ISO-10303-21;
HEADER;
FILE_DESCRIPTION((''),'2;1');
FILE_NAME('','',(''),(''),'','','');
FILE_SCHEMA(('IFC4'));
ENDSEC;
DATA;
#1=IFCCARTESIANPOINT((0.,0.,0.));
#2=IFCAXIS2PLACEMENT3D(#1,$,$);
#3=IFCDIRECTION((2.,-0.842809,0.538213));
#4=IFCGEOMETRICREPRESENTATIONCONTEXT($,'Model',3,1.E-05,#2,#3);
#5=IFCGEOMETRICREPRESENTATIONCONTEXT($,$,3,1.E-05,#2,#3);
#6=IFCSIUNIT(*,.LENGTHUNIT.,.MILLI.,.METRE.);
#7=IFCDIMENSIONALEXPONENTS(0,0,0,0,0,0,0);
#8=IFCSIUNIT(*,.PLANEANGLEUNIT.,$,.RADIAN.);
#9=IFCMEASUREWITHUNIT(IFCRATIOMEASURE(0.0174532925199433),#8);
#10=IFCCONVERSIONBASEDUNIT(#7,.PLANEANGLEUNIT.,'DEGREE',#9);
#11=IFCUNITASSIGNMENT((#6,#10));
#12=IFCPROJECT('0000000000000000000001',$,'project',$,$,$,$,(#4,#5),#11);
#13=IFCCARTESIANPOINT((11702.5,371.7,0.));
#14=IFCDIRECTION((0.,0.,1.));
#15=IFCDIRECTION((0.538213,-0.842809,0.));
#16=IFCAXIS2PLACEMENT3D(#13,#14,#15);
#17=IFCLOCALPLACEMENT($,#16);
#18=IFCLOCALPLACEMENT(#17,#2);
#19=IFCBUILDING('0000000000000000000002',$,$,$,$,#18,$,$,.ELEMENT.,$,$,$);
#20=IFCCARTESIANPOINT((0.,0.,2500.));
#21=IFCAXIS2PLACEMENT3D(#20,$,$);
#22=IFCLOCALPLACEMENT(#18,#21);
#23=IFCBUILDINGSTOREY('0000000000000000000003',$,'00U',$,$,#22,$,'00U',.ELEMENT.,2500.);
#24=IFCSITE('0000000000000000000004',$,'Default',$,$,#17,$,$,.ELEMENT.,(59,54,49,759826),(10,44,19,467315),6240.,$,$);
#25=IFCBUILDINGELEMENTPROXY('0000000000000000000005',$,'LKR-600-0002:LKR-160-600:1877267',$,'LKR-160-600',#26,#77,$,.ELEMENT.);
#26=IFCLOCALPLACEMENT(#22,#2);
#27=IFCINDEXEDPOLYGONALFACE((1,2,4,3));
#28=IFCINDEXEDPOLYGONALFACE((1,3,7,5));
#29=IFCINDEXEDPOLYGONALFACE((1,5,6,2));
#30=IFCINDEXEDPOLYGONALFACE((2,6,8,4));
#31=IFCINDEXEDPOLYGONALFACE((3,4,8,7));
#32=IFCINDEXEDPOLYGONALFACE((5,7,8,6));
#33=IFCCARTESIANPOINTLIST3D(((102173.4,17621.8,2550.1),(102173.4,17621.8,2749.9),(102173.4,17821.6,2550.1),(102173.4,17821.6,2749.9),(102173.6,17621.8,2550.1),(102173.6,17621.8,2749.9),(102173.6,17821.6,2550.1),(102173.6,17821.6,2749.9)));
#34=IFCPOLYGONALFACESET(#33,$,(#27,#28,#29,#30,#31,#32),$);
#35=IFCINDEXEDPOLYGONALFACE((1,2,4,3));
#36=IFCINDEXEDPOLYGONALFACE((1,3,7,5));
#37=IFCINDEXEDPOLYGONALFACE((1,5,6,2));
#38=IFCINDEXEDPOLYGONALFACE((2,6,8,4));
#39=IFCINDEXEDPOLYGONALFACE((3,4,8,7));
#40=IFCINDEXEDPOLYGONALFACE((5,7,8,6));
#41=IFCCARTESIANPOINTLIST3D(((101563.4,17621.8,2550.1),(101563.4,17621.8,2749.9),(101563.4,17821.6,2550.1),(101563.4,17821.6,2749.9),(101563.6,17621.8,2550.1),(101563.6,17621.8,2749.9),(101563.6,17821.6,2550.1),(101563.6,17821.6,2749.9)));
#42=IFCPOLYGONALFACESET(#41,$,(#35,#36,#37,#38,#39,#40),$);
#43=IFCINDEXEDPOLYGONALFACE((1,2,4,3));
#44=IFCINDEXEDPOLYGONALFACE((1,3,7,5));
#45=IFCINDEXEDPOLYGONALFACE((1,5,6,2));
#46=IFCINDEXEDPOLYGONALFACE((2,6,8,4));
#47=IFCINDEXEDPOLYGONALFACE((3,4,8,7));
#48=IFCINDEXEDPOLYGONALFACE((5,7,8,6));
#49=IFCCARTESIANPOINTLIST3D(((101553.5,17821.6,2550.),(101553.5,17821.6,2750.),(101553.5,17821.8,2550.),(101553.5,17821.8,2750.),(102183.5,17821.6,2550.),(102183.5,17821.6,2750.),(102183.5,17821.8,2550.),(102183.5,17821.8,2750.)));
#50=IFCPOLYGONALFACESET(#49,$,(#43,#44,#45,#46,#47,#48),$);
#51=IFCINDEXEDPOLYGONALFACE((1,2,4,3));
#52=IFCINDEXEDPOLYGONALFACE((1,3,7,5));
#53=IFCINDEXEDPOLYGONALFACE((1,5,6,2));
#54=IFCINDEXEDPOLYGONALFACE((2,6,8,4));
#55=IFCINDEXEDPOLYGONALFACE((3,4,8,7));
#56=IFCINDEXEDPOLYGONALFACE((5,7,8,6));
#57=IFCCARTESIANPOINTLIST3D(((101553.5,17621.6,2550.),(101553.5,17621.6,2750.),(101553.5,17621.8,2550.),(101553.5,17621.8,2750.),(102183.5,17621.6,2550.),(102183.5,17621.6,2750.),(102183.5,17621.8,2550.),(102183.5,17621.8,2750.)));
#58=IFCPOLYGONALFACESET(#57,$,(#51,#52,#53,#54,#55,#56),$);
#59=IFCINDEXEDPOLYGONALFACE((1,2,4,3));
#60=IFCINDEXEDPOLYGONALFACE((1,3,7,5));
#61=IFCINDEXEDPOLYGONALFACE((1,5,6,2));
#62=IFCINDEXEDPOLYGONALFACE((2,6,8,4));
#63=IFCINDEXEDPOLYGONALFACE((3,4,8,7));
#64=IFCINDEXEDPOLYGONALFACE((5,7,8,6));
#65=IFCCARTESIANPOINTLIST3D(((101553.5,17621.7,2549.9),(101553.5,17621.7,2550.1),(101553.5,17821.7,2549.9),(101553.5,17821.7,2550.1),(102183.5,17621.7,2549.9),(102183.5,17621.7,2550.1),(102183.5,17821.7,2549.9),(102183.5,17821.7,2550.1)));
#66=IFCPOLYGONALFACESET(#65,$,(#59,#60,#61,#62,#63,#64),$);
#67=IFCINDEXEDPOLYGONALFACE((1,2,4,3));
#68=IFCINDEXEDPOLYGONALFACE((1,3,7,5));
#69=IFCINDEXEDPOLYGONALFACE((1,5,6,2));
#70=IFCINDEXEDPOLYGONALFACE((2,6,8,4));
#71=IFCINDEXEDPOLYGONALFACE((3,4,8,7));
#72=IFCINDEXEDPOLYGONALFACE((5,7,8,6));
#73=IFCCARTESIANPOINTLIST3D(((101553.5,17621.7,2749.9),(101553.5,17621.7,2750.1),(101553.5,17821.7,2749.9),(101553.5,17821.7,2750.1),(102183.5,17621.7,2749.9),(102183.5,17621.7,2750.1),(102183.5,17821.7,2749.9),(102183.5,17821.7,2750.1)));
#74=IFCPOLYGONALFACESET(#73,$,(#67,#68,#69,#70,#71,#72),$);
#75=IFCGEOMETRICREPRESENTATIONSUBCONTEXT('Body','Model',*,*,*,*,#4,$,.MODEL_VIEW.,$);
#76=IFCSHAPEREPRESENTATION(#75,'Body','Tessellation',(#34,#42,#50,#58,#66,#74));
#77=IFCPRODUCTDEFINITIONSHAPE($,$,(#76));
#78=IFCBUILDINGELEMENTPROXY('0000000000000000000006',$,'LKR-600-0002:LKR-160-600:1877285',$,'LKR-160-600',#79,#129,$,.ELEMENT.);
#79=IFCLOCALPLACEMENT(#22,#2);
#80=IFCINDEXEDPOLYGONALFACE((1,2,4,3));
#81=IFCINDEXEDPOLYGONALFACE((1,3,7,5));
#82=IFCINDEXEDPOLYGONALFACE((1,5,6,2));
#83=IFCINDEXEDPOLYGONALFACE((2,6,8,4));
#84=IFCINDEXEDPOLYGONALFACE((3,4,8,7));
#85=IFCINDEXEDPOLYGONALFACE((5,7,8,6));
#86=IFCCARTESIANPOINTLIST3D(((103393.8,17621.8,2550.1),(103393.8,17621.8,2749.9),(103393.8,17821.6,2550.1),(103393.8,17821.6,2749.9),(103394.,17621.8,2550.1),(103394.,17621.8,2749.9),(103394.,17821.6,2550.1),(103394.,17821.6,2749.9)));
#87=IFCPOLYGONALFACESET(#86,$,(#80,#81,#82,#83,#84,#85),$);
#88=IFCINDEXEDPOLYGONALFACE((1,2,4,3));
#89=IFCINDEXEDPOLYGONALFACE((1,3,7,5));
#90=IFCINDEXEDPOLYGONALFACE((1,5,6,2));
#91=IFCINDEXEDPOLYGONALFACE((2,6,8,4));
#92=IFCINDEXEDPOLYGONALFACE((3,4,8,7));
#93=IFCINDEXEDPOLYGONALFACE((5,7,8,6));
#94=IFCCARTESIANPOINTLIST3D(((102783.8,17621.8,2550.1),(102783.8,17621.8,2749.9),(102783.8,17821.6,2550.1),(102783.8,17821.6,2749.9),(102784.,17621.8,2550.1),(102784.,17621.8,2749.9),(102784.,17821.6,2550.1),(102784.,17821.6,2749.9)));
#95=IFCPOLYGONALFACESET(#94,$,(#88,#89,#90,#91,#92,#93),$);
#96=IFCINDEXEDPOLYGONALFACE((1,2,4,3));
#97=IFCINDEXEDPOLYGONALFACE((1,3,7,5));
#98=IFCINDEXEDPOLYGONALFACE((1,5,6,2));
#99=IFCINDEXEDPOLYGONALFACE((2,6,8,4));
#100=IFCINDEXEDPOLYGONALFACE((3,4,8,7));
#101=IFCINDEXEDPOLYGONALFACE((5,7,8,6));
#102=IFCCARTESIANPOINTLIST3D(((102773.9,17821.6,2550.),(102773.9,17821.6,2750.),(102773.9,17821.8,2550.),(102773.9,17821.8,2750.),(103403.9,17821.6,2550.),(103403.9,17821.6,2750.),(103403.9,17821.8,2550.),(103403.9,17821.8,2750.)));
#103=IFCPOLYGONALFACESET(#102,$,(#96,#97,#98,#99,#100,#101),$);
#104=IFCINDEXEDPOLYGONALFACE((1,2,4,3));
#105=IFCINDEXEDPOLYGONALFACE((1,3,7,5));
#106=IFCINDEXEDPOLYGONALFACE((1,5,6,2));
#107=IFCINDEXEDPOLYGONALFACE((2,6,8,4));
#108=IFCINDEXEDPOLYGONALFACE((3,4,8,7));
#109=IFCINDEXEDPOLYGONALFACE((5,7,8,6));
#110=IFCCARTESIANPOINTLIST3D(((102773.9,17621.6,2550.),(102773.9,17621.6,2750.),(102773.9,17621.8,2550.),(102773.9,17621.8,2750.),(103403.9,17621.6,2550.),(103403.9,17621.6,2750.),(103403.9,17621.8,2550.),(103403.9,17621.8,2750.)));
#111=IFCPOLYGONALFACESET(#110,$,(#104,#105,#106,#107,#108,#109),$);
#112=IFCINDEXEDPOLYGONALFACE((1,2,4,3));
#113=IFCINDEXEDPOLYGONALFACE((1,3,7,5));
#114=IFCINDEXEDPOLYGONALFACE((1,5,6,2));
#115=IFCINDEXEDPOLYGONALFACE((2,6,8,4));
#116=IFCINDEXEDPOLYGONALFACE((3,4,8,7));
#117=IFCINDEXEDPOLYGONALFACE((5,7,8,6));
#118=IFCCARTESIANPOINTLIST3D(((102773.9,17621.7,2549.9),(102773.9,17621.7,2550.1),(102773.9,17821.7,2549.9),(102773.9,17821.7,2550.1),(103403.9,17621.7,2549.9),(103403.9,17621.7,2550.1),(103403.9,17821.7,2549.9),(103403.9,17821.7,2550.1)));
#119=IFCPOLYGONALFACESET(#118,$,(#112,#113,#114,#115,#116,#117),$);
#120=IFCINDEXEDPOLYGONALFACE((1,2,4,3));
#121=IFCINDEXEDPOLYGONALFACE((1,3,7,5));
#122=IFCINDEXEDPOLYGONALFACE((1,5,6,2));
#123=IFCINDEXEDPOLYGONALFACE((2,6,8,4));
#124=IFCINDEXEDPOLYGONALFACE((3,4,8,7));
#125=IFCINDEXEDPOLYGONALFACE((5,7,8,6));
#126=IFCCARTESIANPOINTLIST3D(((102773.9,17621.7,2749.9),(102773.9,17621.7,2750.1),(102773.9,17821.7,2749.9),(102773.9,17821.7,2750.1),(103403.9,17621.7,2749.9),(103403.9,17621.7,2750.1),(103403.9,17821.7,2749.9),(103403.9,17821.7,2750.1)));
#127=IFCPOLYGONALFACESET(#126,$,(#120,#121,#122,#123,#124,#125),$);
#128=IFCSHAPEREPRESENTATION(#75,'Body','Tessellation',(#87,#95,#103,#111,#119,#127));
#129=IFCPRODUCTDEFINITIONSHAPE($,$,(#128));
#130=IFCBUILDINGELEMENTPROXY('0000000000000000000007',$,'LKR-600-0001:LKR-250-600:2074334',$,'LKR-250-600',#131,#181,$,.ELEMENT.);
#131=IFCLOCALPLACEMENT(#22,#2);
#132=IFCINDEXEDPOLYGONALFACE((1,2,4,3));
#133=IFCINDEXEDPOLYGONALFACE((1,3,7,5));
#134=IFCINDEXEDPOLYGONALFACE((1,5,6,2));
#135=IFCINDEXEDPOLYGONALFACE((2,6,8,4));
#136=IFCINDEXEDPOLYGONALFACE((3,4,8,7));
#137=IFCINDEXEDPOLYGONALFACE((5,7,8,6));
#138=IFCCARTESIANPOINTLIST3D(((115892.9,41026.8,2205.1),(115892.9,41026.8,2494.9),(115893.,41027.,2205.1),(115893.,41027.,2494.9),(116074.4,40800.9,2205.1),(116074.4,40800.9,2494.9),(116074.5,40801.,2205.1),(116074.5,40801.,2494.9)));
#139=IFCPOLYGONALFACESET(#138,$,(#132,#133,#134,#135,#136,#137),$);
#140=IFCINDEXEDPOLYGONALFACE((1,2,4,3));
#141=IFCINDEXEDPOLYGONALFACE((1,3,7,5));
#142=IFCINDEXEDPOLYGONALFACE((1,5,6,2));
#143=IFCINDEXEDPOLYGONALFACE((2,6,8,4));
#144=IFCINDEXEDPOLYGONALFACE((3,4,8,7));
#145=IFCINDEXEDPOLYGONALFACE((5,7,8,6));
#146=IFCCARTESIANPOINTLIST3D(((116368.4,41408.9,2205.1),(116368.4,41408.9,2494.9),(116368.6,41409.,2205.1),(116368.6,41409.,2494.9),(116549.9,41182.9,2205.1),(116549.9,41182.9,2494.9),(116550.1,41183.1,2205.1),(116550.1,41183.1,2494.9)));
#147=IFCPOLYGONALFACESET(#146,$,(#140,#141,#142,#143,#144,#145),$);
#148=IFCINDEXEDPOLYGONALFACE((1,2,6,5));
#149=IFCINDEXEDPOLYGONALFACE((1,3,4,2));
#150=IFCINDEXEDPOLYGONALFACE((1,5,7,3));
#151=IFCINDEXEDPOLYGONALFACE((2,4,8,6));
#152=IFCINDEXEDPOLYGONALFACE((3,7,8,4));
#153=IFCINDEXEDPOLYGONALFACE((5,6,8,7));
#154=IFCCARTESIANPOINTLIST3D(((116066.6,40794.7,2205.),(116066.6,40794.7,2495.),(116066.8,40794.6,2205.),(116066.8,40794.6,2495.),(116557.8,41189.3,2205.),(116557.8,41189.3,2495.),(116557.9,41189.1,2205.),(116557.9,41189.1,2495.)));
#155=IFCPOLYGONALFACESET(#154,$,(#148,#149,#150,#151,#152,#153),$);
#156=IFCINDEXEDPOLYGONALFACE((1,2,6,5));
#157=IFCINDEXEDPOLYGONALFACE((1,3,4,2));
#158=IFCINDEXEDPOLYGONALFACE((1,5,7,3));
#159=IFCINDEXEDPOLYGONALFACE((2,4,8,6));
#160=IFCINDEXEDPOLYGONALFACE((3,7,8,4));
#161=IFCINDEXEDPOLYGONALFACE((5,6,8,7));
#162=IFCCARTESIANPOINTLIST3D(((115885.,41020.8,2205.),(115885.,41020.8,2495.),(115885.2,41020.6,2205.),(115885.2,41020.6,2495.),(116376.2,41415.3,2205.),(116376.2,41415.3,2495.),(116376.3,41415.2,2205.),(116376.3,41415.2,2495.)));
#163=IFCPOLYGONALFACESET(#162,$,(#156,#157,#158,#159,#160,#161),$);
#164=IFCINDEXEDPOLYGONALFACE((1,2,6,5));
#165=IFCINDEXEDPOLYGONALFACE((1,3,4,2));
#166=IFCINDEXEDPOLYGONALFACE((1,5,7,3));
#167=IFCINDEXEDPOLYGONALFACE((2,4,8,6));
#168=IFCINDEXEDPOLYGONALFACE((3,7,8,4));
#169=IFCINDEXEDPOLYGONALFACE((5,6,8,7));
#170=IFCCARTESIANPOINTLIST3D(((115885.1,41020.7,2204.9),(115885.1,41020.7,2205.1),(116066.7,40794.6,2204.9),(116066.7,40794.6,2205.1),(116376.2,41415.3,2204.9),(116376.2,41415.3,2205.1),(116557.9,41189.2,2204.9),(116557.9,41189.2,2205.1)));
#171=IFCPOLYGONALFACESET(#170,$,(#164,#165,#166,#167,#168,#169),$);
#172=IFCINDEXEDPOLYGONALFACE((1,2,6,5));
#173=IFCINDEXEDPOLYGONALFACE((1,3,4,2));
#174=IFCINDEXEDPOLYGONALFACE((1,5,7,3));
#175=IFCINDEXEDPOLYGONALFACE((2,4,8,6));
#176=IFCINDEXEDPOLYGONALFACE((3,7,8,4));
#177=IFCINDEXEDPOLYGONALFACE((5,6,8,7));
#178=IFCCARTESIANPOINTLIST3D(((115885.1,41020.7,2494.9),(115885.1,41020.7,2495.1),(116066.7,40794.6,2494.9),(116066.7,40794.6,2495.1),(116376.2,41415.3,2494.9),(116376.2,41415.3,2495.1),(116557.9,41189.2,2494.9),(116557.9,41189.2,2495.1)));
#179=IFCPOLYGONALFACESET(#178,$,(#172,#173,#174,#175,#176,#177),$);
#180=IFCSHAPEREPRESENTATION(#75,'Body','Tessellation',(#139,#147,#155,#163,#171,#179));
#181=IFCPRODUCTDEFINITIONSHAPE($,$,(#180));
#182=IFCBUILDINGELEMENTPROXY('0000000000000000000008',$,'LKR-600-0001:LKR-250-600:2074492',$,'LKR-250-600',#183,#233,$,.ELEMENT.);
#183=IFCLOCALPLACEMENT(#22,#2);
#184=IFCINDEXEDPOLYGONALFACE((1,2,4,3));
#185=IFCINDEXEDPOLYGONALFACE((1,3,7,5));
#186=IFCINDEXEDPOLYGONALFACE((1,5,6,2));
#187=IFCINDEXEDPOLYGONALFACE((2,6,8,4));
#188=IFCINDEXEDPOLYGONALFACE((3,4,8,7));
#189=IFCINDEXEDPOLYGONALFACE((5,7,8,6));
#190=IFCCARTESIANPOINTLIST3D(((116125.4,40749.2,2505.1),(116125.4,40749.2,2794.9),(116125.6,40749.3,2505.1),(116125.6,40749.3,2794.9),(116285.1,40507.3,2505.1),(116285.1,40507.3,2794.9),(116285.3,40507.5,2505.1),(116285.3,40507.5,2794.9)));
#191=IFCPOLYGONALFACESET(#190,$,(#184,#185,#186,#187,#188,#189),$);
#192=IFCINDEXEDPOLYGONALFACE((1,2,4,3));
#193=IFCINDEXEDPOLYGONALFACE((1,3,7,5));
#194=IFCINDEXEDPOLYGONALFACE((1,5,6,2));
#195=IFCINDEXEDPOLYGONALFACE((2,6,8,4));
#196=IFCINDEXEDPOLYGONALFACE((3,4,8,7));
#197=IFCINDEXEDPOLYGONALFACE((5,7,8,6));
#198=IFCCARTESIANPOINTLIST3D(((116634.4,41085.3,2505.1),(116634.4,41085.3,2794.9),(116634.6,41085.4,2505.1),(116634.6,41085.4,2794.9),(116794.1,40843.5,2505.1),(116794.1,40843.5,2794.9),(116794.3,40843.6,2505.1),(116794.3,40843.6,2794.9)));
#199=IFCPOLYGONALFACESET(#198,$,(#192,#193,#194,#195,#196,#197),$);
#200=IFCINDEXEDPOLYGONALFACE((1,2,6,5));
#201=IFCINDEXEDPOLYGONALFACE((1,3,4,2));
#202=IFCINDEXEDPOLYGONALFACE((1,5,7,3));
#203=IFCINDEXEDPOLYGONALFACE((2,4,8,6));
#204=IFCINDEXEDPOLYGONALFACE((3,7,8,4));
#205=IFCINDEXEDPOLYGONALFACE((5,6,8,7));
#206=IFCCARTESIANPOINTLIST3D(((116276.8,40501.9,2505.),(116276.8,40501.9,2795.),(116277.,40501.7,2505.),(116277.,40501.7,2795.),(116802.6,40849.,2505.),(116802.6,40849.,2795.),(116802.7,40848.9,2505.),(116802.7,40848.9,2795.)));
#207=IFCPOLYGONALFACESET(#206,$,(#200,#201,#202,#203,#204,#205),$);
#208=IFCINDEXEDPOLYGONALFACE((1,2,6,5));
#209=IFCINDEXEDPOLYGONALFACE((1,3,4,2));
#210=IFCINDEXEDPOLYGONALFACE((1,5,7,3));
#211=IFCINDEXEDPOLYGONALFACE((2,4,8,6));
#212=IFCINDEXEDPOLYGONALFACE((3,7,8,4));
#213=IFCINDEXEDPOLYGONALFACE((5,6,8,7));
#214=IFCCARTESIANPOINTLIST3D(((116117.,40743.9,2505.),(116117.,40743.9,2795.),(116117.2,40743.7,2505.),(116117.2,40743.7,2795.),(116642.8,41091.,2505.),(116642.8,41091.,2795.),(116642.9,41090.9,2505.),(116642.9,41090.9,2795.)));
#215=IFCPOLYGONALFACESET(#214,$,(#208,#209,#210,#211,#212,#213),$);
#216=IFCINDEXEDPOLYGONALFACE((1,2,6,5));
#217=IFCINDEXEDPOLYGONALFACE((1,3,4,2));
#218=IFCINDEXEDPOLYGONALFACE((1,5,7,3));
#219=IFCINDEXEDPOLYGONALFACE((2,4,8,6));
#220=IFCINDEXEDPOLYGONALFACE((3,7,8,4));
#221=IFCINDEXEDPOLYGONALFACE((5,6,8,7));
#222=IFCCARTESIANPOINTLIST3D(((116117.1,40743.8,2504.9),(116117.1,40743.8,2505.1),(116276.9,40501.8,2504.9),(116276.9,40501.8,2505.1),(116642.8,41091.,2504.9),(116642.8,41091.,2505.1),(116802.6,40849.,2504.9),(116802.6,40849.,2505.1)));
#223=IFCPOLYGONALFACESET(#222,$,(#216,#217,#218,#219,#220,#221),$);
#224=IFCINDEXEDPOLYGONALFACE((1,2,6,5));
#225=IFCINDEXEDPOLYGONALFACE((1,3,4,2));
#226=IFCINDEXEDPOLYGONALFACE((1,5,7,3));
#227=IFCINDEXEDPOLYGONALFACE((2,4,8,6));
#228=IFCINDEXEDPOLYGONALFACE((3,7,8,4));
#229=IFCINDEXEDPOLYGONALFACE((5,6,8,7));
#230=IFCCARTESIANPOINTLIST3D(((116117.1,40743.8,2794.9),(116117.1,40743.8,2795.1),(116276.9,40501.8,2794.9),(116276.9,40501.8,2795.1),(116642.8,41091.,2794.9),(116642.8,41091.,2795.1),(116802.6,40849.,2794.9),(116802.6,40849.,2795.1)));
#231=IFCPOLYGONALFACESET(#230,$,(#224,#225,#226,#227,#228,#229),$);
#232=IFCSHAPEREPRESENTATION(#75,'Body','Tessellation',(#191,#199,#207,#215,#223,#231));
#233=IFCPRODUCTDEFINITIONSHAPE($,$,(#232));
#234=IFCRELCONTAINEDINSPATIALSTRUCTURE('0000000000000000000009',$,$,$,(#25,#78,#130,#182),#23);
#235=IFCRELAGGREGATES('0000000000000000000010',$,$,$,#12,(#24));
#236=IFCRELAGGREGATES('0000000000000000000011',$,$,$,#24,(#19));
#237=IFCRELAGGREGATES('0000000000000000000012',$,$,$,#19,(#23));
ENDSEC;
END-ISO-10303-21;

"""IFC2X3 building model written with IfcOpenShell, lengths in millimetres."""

from ifc_helpers import new_model, entity, si_unit, converted_unit, direction, frame, frame_2d, origin, origin_2d_with_axis, place, context, subcontext, project, spatial, rectangle, extrude, source, transform, mapped, element, save


model = new_model("IFC2X3")

# Units and contexts
model_context = context("Model", 3, precision=1e-05, world=origin(), true_north=direction((2.0, -0.842809, 0.538213)))
context_of_model = context(None, 3, precision=1e-05, world=origin(), true_north=direction((2.0, -0.842809, 0.538213)))
body_context = subcontext(model_context, "Body", "Model", "MODEL_VIEW")
ifc_project = project(units=[si_unit("LENGTHUNIT", "METRE", prefix="MILLI"), converted_unit("PLANEANGLEUNIT", "DEGREE", entity("IfcRatioMeasure", 0.0174532925199433), si_unit("PLANEANGLEUNIT", "RADIAN"), dimensions=[0, 0, 0, 0, 0, 0, 0])], contexts=[model_context, context_of_model])

# Site, building, storey
site_placement = place(None, frame((11702.5, 371.7, 0.0), z_axis=(0.0, 0.0, 1.0), x_axis=(0.538213, -0.842809, 0.0)))
site = spatial("IfcSite", under=ifc_project, at=site_placement, Name="Default", CompositionType="ELEMENT", RefLatitude=(59, 54, 49, 759826), RefLongitude=(10, 44, 19, 467315), RefElevation=6240.0)
building_placement = place(site_placement, origin())
building = spatial("IfcBuilding", under=site, at=building_placement, CompositionType="ELEMENT")
storey_placement = place(building_placement, frame((0.0, 0.0, 2500.0)))
storey = spatial("IfcBuildingStorey", under=building, at=storey_placement, Name="00U", LongName="00U", CompositionType="ELEMENT", Elevation=2500.0)

# Building element proxies
shared_shape_1 = source(origin(), body_context, "Body", "SweptSolid", [
    extrude(rectangle(XDim=0.2, YDim=199.8, at=frame_2d((0.0, 0.0), x_axis=(1.0, 0.0))), frame((305.0, 0.0, -99.9)), (0.0, 0.0, 1.0), 199.8),
    extrude(rectangle(XDim=0.2, YDim=199.8, at=frame_2d((0.0, 0.0), x_axis=(1.0, 0.0))), frame((-305.0, 0.0, -99.9)), (0.0, 0.0, 1.0), 199.8),
    extrude(rectangle(XDim=0.2, YDim=630.0, at=frame_2d((0.0, 0.0), x_axis=(1.0, 0.0))), frame((0.0, 100.0, -100.0), z_axis=(0.0, 0.0, 1.0), x_axis=(0.0, 1.0, 0.0)), (0.0, 0.0, 1.0), 200.0),
    extrude(rectangle(XDim=0.2, YDim=630.0, at=frame_2d((0.0, 0.0), x_axis=(1.0, 0.0))), frame((0.0, -100.0, -100.0), z_axis=(0.0, 0.0, 1.0), x_axis=(0.0, 1.0, 0.0)), (0.0, 0.0, 1.0), 200.0),
    extrude(rectangle(XDim=200.0, YDim=630.0, at=origin_2d_with_axis()), frame((0.0, 0.0, -100.1), z_axis=(0.0, 0.0, 1.0), x_axis=(0.0, -1.0, 0.0)), (0.0, 0.0, 1.0), 0.2),
    extrude(rectangle(XDim=200.0, YDim=630.0, at=origin_2d_with_axis()), frame((0.0, 0.0, 99.9), z_axis=(0.0, 0.0, 1.0), x_axis=(0.0, -1.0, 0.0)), (0.0, 0.0, 1.0), 0.2),
])
for number, where, name in (
    (1, (101868.5, 17721.7, 2650.0), "LKR-600-0002:LKR-160-600:1877267"),
    (2, (103088.9, 17721.7, 2650.0), "LKR-600-0002:LKR-160-600:1877285"),
):
    element("IfcBuildingElementProxy", number, at=place(storey_placement, frame(where)), inside=storey, Name=name, ObjectType="LKR-160-600", CompositionType="ELEMENT", context=body_context, shape_type="MappedRepresentation", body=[
        mapped(shared_shape_1, transform((0.0, 0.0, 0.0), scale=1.0)),
    ])
shared_shape_2 = source(origin(), body_context, "Body", "SweptSolid", [
    extrude(rectangle(XDim=0.2, YDim=289.8, at=frame_2d((0.0, 0.0), x_axis=(1.0, 0.0))), frame((305.0, 0.0, -144.9)), (0.0, 0.0, 1.0), 289.8),
    extrude(rectangle(XDim=0.2, YDim=289.8, at=frame_2d((0.0, 0.0), x_axis=(1.0, 0.0))), frame((-305.0, 0.0, -144.9)), (0.0, 0.0, 1.0), 289.8),
    extrude(rectangle(XDim=0.2, YDim=630.0, at=frame_2d((0.0, 0.0), x_axis=(1.0, 0.0))), frame((0.0, 145.0, -145.0), z_axis=(0.0, 0.0, 1.0), x_axis=(0.0, 1.0, 0.0)), (0.0, 0.0, 1.0), 290.0),
    extrude(rectangle(XDim=0.2, YDim=630.0, at=frame_2d((0.0, 0.0), x_axis=(1.0, 0.0))), frame((0.0, -145.0, -145.0), z_axis=(0.0, 0.0, 1.0), x_axis=(0.0, 1.0, 0.0)), (0.0, 0.0, 1.0), 290.0),
    extrude(rectangle(XDim=290.0, YDim=630.0, at=origin_2d_with_axis()), frame((0.0, 0.0, -145.1), z_axis=(0.0, 0.0, 1.0), x_axis=(0.0, -1.0, 0.0)), (0.0, 0.0, 1.0), 0.2),
    extrude(rectangle(XDim=290.0, YDim=630.0, at=origin_2d_with_axis()), frame((0.0, 0.0, 144.9), z_axis=(0.0, 0.0, 1.0), x_axis=(0.0, -1.0, 0.0)), (0.0, 0.0, 1.0), 0.2),
])
for number, where, z_axis, x_axis, name in (
    (3, (116221.5, 41104.9, 2350.0), (0.0, 0.0, 1.0), (-0.779613, -0.626261, 0.0), "LKR-600-0001:LKR-250-600:2074334"),
    (4, (116459.9, 40796.4, 2650.0), (0.0, 0.0, 1.0), (-0.834483, -0.551033, 0.0), "LKR-600-0001:LKR-250-600:2074492"),
):
    element("IfcBuildingElementProxy", number, at=place(storey_placement, frame(where, z_axis=z_axis, x_axis=x_axis)), inside=storey, Name=name, ObjectType="LKR-250-600", CompositionType="ELEMENT", context=body_context, shape_type="MappedRepresentation", body=[
        mapped(shared_shape_2, transform((0.0, 0.0, 0.0), scale=1.0)),
    ])

save(model, "model.ifc")
